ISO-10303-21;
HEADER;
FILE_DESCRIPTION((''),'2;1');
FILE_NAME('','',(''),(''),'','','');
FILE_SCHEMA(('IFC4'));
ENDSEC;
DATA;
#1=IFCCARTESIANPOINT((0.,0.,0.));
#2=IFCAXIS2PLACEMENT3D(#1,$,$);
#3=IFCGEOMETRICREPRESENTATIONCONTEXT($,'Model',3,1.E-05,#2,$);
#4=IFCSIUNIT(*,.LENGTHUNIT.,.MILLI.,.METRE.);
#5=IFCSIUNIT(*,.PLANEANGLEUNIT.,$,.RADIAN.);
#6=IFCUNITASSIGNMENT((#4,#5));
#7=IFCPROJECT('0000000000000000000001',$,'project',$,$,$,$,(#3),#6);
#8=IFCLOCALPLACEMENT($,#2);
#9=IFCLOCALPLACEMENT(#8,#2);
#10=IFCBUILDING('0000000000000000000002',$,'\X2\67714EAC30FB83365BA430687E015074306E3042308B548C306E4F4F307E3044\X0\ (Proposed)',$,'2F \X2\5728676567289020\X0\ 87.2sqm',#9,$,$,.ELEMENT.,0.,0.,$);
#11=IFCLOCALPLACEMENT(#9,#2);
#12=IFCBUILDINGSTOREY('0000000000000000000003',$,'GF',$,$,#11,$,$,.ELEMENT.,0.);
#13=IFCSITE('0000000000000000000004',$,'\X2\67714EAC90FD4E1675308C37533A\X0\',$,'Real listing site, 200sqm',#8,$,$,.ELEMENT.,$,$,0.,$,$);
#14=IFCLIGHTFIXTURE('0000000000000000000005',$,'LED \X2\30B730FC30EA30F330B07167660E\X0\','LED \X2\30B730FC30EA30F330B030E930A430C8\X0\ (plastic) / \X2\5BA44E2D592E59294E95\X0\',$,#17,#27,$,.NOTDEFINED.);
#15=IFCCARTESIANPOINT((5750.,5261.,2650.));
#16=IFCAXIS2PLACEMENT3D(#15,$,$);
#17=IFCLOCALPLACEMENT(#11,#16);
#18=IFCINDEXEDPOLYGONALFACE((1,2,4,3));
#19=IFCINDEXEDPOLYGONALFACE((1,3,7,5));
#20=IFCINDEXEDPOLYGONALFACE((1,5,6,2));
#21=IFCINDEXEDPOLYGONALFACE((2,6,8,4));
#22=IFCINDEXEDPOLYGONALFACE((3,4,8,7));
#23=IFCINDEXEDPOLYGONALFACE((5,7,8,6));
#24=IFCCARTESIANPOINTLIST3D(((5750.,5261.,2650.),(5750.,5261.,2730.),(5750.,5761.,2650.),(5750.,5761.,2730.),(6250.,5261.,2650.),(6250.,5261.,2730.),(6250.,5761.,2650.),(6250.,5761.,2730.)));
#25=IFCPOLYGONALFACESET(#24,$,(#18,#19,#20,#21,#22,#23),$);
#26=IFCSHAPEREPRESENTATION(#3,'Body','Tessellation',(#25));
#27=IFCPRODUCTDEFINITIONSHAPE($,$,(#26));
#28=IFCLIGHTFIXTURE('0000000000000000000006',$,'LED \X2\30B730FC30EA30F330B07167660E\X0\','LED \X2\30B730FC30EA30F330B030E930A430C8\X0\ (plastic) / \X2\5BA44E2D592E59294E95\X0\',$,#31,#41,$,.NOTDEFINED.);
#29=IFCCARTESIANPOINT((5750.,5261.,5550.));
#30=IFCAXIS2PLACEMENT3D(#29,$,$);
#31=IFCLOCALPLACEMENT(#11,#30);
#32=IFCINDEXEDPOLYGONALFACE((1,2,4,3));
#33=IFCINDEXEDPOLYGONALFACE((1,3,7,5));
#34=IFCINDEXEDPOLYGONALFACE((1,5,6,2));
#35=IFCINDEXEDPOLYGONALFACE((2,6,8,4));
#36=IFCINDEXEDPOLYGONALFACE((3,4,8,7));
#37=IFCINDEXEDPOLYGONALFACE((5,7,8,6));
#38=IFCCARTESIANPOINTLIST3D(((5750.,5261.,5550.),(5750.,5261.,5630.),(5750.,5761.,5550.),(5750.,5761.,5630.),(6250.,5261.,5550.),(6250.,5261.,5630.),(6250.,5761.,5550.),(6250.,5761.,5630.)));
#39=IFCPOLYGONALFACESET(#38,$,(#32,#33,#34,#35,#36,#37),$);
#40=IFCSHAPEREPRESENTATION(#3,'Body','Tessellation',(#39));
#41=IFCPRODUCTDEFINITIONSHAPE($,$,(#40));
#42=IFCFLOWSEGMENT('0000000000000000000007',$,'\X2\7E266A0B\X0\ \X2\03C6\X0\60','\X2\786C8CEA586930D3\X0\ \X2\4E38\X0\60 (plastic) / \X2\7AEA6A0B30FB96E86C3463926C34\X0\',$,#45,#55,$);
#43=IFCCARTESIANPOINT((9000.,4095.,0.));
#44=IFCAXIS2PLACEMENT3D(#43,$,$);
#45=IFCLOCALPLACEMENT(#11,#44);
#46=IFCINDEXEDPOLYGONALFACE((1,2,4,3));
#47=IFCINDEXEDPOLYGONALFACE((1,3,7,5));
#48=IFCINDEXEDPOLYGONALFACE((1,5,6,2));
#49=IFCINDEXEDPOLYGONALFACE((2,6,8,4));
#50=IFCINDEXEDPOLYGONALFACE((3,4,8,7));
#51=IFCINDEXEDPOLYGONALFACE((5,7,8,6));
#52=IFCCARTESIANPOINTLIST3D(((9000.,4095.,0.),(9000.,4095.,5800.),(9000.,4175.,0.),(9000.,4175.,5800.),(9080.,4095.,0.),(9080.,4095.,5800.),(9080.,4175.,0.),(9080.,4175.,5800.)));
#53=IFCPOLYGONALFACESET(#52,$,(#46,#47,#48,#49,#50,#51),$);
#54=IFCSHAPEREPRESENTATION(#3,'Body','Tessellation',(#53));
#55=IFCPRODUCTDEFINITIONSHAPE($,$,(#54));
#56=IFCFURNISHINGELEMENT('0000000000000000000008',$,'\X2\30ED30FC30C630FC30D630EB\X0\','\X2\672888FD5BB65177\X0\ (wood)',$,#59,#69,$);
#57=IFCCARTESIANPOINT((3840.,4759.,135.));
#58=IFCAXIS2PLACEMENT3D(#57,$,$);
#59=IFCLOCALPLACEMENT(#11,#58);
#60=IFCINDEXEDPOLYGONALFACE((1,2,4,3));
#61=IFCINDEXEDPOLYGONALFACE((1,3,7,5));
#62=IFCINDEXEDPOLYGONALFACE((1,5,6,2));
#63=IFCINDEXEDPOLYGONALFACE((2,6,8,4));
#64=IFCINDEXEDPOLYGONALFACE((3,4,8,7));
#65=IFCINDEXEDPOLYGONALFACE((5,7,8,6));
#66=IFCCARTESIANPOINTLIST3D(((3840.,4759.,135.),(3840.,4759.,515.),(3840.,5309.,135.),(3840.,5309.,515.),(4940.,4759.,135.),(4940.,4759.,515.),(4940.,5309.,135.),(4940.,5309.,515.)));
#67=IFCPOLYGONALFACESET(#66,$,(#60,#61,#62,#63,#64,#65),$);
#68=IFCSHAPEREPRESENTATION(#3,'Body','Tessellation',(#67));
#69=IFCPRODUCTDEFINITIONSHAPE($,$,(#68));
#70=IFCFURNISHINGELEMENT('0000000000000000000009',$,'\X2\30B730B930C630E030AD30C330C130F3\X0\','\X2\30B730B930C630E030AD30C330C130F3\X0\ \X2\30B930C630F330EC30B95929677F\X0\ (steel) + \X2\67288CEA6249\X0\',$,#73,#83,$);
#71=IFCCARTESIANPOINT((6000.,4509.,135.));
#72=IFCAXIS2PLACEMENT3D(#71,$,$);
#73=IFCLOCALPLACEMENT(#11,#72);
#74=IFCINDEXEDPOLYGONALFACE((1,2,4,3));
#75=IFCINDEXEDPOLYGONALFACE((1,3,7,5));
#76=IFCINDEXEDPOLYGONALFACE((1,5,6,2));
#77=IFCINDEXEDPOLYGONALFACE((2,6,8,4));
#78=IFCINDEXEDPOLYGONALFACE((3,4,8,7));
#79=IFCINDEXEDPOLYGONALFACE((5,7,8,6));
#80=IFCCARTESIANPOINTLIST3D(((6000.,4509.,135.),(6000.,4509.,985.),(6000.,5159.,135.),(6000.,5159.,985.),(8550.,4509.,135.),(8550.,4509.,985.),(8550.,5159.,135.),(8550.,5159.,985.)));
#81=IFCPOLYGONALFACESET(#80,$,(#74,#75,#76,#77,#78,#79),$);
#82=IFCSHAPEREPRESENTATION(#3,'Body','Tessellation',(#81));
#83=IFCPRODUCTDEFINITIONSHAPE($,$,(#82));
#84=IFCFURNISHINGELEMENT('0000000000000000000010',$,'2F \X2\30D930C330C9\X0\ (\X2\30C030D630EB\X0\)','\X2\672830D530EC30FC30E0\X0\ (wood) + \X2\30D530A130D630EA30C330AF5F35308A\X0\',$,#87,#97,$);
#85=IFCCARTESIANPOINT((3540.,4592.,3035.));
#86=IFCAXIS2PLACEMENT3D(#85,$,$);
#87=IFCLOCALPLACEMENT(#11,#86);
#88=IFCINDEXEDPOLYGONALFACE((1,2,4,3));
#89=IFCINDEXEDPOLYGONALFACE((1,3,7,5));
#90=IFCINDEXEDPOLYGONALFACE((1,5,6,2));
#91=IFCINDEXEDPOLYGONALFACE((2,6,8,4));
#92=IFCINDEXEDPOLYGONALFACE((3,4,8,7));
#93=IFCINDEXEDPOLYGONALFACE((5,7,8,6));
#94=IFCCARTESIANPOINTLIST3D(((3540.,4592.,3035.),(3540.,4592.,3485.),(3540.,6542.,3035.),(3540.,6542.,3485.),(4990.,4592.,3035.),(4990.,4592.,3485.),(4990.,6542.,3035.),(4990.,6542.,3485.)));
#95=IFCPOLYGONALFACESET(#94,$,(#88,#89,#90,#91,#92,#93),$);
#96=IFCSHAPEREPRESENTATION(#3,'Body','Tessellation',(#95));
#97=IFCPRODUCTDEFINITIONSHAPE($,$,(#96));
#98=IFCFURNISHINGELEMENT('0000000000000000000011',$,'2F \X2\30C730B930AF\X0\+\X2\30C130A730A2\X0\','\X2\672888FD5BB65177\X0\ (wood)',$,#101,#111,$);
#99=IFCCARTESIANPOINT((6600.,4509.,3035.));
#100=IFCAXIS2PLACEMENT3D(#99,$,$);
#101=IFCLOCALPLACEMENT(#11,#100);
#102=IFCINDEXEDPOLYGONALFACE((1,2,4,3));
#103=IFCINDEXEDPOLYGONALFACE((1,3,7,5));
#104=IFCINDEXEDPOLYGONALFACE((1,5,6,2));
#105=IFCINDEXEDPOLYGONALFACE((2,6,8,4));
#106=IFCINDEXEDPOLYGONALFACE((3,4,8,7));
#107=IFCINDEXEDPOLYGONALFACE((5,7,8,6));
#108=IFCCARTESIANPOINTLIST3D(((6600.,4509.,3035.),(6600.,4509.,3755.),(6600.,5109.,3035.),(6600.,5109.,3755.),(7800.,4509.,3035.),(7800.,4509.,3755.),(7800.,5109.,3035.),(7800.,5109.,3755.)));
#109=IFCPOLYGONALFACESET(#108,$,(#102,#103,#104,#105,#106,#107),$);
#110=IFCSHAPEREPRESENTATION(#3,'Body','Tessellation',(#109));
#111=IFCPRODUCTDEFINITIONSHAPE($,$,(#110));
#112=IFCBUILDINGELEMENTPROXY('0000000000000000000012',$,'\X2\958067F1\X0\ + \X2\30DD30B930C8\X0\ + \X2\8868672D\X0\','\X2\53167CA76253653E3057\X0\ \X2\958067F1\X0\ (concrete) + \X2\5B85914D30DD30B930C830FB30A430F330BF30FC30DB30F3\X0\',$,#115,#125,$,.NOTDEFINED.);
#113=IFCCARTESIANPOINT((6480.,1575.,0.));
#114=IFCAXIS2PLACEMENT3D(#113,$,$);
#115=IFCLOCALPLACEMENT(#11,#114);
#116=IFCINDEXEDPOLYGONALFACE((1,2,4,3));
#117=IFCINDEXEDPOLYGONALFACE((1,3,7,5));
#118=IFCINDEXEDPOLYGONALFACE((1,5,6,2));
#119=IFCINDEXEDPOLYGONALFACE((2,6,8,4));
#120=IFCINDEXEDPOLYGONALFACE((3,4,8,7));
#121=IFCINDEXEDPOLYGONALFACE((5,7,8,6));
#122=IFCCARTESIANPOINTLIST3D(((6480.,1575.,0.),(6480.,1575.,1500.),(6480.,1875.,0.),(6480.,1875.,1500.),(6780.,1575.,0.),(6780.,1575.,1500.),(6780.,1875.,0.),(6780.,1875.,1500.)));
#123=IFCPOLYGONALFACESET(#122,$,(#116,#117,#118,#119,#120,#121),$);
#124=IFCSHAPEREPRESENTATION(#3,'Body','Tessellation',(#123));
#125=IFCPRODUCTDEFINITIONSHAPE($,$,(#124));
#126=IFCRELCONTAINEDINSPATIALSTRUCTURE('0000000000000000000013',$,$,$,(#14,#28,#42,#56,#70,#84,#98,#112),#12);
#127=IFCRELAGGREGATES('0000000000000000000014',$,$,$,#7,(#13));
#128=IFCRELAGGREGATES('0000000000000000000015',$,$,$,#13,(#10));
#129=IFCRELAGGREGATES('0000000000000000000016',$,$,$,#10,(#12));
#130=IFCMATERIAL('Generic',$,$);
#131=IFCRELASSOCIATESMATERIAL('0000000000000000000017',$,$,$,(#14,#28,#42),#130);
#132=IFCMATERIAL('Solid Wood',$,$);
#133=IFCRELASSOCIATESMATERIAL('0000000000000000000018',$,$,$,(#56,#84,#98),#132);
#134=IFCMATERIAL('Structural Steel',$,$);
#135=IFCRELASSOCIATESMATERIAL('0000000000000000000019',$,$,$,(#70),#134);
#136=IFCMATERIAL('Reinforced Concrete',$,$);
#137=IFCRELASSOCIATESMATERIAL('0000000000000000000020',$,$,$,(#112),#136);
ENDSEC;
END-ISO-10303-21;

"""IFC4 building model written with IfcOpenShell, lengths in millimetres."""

from ifc_helpers import new_model, si_unit, frame, frame_2d, origin, place, context, project, spatial, rectangle, extrude, material, element, save


model = new_model("IFC4")

# Units and contexts
model_context = context("Model", 3, precision=1e-05, world=origin())
ifc_project = project(units=[si_unit("LENGTHUNIT", "METRE", prefix="MILLI"), si_unit("PLANEANGLEUNIT", "RADIAN")], contexts=[model_context])

# Site, building, storey
site_placement = place(None, origin())
site = spatial("IfcSite", under=ifc_project, at=site_placement, Name="東京都世田谷区", ObjectType="Real listing site, 200sqm", CompositionType="ELEMENT", RefElevation=0.0)
building_placement = place(site_placement, origin())
building = spatial("IfcBuilding", under=site, at=building_placement, Name="東京・茶室と縁側のある和の住まい (Proposed)", ObjectType="2F 在来木造 87.2sqm", CompositionType="ELEMENT", ElevationOfRefHeight=0.0, ElevationOfTerrain=0.0)
storey_placement = place(building_placement, origin())
storey = spatial("IfcBuildingStorey", under=building, at=storey_placement, Name="GF", CompositionType="ELEMENT", Elevation=0.0)

# Shared definitions
ifc_material_1 = material(Name="Solid Wood")

# Shared definitions
ifc_material_2 = material(Name="Reinforced Concrete")

# Shared definitions
ifc_material_3 = material(Name="Structural Steel")

# Shared definitions
ifc_material_4 = material(Name="Generic")

# Light fixtures
light_fixture_1_placement = place(storey_placement, frame((5750.0, 5261.0, 2650.0)))
element("IfcLightFixture", 1, at=light_fixture_1_placement, inside=storey, material=ifc_material_4, Name="LED シーリング照明", Description="LED シーリングライト (plastic) / 室中央天井", PredefinedType="NOTDEFINED", context=model_context, shape_type="SweptSolid", body=[
    extrude(rectangle(XDim=500.0, YDim=500.0, at=frame_2d((250.0, 250.0))), frame((5750.0, 5261.0, 2650.0)), (0.0, 0.0, 1.0), 80.0),
])
light_fixture_2_placement = place(storey_placement, frame((5750.0, 5261.0, 5550.0)))
element("IfcLightFixture", 2, at=light_fixture_2_placement, inside=storey, material=ifc_material_4, Name="LED シーリング照明", Description="LED シーリングライト (plastic) / 室中央天井", PredefinedType="NOTDEFINED", context=model_context, shape_type="SweptSolid", body=[
    extrude(rectangle(XDim=500.0, YDim=500.0, at=frame_2d((250.0, 250.0))), frame((5750.0, 5261.0, 5550.0)), (0.0, 0.0, 1.0), 80.0),
])

# Flow segment
flow_segment_placement = place(storey_placement, frame((9000.0, 4095.0, 0.0)))
element("IfcFlowSegment", 3, at=flow_segment_placement, inside=storey, material=ifc_material_4, Name="縦樋 φ60", Description="硬質塩ビ 丸60 (plastic) / 竪樋・雨水排水", context=model_context, shape_type="SweptSolid", body=[
    extrude(rectangle(XDim=80.0, YDim=80.0, at=frame_2d((40.0, 40.0))), frame((9000.0, 4095.0, 0.0)), (0.0, 0.0, 1.0), 5800.0),
])

# Furnishing elements
furnishing_1_placement = place(storey_placement, frame((3840.0, 4759.0, 135.0)))
element("IfcFurnishingElement", 4, at=furnishing_1_placement, inside=storey, material=ifc_material_1, Name="ローテーブル", Description="木製家具 (wood)", context=model_context, shape_type="SweptSolid", body=[
    extrude(rectangle(XDim=1100.0, YDim=550.0, at=frame_2d((550.0, 275.0))), frame((3840.0, 4759.0, 135.0)), (0.0, 0.0, 1.0), 380.0),
])
furnishing_2_placement = place(storey_placement, frame((6000.0, 4509.0, 135.0)))
element("IfcFurnishingElement", 5, at=furnishing_2_placement, inside=storey, material=ifc_material_3, Name="システムキッチン", Description="システムキッチン ステンレス天板 (steel) + 木質扉", context=model_context, shape_type="SweptSolid", body=[
    extrude(rectangle(XDim=2550.0, YDim=650.0, at=frame_2d((1275.0, 325.0))), frame((6000.0, 4509.0, 135.0)), (0.0, 0.0, 1.0), 850.0),
])
furnishing_3_placement = place(storey_placement, frame((3540.0, 4592.0, 3035.0)))
element("IfcFurnishingElement", 6, at=furnishing_3_placement, inside=storey, material=ifc_material_1, Name="2F ベッド (ダブル)", Description="木フレーム (wood) + ファブリック張り", context=model_context, shape_type="SweptSolid", body=[
    extrude(rectangle(XDim=1450.0, YDim=1950.0, at=frame_2d((725.0, 975.0))), frame((3540.0, 4592.0, 3035.0)), (0.0, 0.0, 1.0), 450.0),
])
furnishing_4_placement = place(storey_placement, frame((6600.0, 4509.0, 3035.0)))
element("IfcFurnishingElement", 7, at=furnishing_4_placement, inside=storey, material=ifc_material_1, Name="2F デスク+チェア", Description="木製家具 (wood)", context=model_context, shape_type="SweptSolid", body=[
    extrude(rectangle(XDim=1200.0, YDim=600.0, at=frame_2d((600.0, 300.0))), frame((6600.0, 4509.0, 3035.0)), (0.0, 0.0, 1.0), 720.0),
])

# Building element proxy
proxy_placement = place(storey_placement, frame((6480.0, 1575.0, 0.0)))
element("IfcBuildingElementProxy", 8, at=proxy_placement, inside=storey, material=ifc_material_2, Name="門柱 + ポスト + 表札", Description="化粧打放し 門柱 (concrete) + 宅配ポスト・インターホン", PredefinedType="NOTDEFINED", context=model_context, shape_type="SweptSolid", body=[
    extrude(rectangle(XDim=300.0, YDim=300.0, at=frame_2d((150.0, 150.0))), frame((6480.0, 1575.0, 0.0)), (0.0, 0.0, 1.0), 1500.0),
])

save(model, "model.ifc")
